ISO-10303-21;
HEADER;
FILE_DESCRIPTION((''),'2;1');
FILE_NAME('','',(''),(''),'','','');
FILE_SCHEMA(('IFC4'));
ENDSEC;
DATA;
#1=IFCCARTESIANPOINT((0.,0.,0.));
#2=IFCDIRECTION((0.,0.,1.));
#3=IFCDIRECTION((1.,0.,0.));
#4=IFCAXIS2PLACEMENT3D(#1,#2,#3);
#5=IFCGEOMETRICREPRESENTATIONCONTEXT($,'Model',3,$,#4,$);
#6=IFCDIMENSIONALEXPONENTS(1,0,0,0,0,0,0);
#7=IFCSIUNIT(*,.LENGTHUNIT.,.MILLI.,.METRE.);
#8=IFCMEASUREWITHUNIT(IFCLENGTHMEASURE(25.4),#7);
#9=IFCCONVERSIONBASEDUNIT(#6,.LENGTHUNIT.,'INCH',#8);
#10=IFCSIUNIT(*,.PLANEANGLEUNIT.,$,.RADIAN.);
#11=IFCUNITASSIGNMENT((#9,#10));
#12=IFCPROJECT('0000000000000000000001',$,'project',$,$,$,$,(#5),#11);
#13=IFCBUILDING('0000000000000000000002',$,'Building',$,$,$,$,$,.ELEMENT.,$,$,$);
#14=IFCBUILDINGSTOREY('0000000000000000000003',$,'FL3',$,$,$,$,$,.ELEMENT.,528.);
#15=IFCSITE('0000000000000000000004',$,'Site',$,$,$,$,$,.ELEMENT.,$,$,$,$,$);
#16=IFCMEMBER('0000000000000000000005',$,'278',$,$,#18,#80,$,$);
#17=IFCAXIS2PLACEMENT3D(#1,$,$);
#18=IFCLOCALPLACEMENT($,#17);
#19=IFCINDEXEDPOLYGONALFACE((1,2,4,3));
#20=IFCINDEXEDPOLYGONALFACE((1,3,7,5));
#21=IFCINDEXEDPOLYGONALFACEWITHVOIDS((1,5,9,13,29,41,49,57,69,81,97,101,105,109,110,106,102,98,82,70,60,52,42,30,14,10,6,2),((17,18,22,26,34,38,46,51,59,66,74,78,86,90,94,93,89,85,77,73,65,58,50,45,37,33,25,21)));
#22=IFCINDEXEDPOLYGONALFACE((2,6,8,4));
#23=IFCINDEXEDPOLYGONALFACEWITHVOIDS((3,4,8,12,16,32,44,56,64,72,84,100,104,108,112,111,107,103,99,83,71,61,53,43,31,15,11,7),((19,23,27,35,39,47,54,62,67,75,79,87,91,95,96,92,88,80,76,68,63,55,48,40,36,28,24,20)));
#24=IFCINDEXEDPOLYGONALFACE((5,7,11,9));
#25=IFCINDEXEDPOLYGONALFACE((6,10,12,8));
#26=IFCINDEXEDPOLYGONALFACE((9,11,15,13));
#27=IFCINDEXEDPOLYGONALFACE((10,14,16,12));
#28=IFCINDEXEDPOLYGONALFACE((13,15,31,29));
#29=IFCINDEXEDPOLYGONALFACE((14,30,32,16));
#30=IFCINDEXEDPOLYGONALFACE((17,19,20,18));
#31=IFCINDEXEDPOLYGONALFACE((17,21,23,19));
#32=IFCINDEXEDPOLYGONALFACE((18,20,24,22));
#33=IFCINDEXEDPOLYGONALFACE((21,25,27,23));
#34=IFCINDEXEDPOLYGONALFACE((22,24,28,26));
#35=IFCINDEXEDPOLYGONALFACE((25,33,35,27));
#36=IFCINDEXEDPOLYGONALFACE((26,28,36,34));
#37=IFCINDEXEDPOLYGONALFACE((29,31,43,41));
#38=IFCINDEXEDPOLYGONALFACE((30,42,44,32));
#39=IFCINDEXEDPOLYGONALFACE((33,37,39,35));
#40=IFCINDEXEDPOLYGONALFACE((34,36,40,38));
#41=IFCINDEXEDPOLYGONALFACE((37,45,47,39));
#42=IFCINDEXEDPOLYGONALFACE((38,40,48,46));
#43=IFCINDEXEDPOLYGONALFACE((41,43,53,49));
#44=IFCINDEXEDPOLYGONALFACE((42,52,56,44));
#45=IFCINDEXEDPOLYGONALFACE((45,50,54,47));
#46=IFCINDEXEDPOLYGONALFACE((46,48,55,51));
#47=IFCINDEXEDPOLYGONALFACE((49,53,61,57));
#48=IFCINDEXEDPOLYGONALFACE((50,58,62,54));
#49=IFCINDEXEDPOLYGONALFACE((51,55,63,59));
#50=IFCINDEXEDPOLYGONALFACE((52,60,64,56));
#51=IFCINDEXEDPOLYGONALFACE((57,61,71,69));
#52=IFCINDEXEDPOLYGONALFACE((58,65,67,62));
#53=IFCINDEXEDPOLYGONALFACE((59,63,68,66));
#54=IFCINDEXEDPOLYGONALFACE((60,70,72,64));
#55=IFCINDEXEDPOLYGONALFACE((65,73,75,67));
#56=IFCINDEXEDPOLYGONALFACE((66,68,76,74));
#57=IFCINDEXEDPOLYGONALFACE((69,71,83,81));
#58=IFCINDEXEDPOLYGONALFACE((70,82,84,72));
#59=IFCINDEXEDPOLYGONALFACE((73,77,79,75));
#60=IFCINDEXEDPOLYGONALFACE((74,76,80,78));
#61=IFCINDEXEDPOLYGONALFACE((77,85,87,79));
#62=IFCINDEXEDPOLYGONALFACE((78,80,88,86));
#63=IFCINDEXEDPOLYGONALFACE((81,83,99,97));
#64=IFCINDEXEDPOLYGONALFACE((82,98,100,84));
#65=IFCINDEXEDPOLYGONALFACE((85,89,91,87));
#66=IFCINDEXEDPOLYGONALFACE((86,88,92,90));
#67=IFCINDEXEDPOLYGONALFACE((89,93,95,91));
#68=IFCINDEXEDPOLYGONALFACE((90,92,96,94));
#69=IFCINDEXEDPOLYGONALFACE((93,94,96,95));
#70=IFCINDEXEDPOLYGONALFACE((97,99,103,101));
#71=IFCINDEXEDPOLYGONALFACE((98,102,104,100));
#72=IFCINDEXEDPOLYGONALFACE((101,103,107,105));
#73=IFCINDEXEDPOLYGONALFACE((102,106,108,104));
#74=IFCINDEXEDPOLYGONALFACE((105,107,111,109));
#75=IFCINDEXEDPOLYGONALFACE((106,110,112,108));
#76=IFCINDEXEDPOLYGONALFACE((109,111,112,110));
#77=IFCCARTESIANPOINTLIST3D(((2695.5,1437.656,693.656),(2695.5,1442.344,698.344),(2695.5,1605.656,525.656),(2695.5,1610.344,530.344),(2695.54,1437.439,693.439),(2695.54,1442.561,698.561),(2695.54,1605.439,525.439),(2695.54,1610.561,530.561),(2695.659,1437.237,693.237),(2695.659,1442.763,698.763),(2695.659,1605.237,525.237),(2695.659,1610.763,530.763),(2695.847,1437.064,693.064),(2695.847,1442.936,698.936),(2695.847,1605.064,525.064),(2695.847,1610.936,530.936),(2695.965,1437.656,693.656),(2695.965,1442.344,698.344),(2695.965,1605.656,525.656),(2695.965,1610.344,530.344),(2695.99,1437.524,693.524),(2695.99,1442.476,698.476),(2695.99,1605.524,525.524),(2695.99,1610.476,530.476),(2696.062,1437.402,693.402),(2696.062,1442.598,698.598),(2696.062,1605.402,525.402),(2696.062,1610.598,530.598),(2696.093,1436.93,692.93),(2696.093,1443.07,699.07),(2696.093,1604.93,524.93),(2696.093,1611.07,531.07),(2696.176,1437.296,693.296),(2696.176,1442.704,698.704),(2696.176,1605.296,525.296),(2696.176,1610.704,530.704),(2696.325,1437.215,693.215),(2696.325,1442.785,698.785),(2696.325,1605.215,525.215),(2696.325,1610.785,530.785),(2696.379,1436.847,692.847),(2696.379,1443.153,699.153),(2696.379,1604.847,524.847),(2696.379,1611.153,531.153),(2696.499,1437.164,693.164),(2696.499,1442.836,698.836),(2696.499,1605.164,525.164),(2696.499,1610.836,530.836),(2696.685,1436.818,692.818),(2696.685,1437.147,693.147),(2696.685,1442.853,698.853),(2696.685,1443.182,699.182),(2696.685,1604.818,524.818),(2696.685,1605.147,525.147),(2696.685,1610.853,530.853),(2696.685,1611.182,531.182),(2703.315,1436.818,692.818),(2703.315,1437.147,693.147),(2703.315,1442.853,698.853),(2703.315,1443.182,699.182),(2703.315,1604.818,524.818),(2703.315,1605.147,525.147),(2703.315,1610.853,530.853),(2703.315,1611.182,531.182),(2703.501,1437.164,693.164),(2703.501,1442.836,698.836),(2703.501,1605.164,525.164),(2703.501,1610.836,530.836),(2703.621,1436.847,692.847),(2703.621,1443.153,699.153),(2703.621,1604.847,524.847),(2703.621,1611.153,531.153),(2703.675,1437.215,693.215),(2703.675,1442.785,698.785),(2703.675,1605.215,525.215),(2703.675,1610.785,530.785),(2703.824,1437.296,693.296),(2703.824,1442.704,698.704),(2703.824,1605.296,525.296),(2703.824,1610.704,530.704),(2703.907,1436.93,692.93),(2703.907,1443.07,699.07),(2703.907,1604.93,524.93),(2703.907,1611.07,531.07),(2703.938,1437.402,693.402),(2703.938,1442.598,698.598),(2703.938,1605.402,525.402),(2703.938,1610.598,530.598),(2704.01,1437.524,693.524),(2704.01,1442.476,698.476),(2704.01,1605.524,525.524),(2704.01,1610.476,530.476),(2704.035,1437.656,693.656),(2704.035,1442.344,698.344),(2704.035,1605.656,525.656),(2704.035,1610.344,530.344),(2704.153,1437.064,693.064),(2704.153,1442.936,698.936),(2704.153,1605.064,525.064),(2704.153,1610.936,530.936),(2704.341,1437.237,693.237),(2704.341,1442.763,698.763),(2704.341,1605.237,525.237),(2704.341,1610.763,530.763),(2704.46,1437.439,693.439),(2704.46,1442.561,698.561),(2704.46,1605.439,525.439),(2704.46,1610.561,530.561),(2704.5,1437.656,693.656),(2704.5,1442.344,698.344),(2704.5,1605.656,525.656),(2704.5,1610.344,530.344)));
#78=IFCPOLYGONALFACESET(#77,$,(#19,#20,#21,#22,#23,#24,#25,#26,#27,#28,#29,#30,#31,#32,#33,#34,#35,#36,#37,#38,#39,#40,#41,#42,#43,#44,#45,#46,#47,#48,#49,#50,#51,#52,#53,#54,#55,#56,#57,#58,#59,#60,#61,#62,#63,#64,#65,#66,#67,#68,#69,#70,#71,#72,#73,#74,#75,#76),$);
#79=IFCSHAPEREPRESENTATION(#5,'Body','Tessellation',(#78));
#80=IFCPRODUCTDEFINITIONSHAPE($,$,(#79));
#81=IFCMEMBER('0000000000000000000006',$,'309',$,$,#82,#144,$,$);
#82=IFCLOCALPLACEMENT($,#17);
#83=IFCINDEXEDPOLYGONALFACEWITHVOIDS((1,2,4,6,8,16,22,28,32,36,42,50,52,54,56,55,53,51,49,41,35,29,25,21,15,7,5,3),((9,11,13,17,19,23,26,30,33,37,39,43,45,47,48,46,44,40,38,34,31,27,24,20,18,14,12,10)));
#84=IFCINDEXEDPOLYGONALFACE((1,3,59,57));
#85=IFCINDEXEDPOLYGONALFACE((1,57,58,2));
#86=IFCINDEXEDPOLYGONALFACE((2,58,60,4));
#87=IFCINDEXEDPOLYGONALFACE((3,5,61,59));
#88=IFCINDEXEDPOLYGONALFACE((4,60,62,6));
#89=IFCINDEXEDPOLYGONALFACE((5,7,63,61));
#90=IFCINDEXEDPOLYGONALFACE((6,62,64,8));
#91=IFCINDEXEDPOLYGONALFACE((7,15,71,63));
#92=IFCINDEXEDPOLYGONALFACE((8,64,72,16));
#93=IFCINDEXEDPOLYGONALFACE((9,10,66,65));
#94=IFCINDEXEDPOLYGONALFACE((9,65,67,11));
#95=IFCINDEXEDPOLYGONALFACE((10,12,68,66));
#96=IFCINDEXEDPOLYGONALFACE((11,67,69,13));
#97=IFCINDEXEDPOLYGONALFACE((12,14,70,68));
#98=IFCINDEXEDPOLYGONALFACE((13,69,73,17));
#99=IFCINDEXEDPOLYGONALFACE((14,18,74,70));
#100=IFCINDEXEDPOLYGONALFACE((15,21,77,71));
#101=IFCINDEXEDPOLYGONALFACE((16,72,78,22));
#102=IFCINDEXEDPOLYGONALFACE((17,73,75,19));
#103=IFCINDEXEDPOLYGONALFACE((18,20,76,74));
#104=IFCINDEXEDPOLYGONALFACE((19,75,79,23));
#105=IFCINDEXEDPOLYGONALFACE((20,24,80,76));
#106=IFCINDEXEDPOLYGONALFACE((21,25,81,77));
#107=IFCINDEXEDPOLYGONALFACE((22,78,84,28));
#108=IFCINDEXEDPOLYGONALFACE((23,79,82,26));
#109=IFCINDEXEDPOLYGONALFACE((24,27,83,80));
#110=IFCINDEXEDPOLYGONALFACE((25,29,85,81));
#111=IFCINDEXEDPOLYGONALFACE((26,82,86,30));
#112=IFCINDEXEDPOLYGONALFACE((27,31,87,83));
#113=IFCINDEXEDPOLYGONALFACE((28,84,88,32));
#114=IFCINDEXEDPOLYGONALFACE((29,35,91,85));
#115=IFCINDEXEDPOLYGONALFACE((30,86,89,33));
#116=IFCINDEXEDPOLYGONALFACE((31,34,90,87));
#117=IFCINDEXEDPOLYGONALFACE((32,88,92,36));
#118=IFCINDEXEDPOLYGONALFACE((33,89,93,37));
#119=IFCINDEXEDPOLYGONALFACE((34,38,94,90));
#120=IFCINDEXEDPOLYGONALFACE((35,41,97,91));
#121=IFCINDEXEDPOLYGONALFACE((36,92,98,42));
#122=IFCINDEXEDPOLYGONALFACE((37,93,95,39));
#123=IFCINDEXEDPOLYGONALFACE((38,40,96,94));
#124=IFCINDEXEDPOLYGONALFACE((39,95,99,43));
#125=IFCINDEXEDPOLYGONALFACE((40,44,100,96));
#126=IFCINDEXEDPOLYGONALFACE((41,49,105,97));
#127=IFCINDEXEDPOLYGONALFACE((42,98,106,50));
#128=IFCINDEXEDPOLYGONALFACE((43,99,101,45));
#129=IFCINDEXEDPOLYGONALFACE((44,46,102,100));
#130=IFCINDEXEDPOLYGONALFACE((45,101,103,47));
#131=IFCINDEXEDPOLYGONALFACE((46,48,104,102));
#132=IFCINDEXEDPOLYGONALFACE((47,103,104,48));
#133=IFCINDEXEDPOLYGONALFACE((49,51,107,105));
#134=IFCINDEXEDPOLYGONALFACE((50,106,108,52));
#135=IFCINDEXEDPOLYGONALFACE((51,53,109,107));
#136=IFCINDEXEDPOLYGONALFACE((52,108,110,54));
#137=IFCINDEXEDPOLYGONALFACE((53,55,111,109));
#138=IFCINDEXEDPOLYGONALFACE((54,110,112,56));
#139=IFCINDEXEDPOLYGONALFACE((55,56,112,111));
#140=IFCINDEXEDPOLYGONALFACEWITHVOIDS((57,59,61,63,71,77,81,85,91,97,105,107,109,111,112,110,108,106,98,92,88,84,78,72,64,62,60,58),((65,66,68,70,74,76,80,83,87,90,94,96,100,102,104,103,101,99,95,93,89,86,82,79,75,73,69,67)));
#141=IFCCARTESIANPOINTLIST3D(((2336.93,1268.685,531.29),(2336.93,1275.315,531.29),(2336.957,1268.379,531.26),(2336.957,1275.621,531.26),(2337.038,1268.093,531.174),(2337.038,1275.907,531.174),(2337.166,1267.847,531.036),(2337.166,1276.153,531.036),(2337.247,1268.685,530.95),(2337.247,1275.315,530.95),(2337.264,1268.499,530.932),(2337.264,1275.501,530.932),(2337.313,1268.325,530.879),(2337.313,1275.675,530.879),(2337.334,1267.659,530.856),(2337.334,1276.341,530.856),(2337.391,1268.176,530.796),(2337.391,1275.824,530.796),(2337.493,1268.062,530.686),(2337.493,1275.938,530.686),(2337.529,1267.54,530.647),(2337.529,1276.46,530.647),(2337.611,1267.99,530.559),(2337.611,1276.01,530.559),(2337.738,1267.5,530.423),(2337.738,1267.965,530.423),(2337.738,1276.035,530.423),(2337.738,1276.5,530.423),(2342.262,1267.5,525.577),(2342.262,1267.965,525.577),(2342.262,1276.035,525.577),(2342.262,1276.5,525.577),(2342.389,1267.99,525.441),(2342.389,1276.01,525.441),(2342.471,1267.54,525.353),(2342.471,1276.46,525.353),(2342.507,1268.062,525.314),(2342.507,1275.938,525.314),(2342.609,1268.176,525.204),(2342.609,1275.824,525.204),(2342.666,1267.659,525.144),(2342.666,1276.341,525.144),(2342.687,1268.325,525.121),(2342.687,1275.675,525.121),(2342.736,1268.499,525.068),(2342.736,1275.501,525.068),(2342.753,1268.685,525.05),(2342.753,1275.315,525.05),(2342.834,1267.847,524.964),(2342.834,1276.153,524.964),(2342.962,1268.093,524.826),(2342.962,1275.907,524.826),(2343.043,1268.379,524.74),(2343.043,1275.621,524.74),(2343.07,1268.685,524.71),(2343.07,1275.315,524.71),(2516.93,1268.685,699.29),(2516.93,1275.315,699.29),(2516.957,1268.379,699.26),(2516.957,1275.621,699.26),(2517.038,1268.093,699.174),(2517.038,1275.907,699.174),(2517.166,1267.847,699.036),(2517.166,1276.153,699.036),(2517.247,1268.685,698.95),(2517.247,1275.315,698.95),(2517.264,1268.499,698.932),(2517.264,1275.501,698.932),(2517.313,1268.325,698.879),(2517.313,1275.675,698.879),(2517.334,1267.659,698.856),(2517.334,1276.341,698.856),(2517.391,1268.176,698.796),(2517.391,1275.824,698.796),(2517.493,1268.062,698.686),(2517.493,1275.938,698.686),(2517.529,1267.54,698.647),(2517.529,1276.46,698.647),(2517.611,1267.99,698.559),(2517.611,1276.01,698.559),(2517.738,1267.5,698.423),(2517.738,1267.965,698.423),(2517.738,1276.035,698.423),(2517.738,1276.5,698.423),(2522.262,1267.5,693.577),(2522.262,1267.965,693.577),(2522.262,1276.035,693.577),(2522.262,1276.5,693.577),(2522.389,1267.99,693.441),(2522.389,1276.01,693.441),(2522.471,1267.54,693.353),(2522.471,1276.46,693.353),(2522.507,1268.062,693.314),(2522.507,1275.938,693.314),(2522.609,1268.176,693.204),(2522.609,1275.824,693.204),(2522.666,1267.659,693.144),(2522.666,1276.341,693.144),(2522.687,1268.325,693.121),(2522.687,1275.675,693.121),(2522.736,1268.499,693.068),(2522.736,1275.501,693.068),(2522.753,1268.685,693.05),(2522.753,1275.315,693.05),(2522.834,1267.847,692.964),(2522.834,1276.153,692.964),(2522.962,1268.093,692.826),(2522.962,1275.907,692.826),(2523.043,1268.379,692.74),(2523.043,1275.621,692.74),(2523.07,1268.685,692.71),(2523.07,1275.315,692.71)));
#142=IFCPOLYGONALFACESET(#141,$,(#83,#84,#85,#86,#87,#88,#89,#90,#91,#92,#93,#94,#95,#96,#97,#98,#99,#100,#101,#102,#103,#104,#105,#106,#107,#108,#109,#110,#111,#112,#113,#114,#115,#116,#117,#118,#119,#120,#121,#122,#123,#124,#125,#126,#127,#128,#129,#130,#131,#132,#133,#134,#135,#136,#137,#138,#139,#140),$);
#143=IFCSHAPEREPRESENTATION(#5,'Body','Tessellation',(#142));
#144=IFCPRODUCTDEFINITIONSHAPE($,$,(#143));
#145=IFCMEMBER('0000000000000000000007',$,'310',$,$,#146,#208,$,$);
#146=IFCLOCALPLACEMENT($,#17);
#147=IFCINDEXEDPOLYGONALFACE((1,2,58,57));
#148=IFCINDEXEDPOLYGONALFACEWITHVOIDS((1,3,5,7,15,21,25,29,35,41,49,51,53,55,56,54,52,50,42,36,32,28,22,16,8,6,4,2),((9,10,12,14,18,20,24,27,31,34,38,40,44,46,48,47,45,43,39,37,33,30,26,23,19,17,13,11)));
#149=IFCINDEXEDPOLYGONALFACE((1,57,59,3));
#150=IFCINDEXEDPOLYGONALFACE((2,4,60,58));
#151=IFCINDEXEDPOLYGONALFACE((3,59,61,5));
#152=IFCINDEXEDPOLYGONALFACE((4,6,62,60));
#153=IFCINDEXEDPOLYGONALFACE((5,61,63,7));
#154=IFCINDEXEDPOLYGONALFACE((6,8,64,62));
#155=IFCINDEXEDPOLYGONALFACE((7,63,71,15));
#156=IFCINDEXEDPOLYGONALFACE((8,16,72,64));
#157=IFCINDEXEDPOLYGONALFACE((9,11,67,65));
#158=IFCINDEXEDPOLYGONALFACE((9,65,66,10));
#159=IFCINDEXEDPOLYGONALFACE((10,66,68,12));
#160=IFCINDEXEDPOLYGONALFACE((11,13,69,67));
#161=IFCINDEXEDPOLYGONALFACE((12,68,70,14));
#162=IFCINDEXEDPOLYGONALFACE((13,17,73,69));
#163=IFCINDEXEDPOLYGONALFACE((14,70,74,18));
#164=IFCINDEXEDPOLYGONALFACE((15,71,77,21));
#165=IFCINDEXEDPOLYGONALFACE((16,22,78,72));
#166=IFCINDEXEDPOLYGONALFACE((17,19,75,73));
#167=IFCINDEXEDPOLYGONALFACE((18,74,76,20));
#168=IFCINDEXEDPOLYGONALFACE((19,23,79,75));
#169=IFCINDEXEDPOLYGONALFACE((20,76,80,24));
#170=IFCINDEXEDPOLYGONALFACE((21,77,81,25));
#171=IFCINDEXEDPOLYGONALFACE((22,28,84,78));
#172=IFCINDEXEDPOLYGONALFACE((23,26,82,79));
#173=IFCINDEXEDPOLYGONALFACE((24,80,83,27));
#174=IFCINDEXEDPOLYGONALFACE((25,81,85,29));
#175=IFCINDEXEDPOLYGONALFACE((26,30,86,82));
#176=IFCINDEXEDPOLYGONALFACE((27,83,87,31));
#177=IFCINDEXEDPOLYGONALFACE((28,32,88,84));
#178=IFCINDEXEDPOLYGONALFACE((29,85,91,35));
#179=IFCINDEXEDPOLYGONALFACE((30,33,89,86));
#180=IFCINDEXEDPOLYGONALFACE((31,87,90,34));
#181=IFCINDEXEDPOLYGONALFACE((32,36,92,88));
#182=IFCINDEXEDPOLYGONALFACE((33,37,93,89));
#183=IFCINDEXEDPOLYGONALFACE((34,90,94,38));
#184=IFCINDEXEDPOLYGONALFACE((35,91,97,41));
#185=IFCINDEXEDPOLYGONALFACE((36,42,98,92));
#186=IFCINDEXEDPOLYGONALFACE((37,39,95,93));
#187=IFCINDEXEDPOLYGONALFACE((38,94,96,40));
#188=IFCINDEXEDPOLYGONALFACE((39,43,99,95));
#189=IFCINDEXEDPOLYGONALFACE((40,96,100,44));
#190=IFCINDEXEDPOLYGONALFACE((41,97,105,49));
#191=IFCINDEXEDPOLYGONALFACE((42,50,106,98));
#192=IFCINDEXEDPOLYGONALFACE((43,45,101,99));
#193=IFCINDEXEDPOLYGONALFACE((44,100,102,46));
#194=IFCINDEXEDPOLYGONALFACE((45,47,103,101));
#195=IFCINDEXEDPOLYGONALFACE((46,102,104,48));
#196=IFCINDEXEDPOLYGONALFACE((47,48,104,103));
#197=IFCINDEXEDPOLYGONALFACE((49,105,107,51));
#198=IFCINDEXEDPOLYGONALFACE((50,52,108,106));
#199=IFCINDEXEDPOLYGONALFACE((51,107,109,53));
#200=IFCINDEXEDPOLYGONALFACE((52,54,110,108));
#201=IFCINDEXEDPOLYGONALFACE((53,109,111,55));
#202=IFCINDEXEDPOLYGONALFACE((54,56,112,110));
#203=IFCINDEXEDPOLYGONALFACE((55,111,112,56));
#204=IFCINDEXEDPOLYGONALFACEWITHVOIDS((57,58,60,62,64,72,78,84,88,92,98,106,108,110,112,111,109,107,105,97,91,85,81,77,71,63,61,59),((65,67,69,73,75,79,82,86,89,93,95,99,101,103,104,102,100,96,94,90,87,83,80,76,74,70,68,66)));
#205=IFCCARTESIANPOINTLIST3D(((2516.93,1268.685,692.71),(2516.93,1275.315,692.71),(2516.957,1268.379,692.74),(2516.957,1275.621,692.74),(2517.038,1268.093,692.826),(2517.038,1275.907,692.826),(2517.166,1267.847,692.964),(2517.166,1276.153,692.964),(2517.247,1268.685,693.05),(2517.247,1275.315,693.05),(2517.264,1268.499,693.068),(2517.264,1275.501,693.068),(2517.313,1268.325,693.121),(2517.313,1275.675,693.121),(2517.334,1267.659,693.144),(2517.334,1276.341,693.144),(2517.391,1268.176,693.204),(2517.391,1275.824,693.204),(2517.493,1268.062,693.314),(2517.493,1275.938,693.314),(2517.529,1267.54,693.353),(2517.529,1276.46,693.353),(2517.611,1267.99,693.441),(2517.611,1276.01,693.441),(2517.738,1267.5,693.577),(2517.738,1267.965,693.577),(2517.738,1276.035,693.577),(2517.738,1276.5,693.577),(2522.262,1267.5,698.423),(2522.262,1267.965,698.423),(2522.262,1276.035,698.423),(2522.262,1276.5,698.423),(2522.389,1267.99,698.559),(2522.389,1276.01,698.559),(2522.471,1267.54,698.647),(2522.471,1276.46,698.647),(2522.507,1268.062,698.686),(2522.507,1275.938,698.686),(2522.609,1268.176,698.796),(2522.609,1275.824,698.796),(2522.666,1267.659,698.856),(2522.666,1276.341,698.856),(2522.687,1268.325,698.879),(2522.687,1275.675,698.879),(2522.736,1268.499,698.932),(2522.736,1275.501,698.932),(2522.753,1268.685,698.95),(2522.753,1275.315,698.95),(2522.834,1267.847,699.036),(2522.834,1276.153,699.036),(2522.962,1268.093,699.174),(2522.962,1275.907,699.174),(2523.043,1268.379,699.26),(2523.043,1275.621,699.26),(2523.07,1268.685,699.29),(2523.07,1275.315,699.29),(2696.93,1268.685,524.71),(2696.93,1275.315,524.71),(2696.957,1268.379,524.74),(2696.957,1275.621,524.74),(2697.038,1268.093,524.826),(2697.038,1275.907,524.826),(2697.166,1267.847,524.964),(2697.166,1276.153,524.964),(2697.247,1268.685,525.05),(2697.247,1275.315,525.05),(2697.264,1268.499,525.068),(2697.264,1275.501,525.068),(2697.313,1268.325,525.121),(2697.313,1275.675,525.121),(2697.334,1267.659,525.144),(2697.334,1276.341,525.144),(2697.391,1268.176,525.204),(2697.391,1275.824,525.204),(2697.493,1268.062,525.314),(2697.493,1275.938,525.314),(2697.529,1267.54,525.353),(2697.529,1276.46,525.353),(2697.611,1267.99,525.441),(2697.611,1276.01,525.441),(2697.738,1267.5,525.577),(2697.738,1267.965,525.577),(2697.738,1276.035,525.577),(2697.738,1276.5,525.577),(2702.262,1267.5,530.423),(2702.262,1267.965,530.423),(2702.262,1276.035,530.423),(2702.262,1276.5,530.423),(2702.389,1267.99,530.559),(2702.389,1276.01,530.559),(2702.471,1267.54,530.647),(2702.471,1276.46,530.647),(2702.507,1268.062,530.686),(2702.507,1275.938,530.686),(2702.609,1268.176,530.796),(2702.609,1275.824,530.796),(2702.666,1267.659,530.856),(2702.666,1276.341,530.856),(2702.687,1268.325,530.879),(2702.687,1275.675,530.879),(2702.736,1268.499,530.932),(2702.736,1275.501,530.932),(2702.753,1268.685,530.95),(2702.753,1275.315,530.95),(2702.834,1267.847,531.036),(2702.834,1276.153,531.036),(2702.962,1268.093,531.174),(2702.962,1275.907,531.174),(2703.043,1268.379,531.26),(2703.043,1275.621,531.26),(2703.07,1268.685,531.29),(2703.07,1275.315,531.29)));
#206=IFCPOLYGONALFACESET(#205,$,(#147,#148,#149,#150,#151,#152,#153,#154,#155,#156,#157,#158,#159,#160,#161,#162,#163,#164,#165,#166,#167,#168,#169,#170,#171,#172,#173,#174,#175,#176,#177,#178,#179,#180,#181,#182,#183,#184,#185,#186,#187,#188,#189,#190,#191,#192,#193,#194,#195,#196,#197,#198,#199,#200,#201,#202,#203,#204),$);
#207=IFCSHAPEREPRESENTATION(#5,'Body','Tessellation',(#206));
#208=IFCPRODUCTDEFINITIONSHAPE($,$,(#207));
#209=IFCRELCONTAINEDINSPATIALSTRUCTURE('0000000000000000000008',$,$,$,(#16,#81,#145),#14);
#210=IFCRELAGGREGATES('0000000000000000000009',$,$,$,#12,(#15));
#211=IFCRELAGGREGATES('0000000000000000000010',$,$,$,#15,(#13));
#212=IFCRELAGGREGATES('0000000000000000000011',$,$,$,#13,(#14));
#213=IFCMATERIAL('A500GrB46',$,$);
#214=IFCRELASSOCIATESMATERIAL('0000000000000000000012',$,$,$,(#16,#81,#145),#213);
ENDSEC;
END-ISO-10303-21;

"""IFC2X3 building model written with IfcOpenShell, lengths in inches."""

from ifc_helpers import new_model, entity, si_unit, converted_unit, frame, origin_with_axes, origin_2d_with_axis, place, context, project, spatial, hollow_rectangle, extrude, material, element, save


model = new_model("IFC2X3")

# Units and contexts
model_context = context("Model", 3, world=origin_with_axes())
ifc_project = project(units=[converted_unit("LENGTHUNIT", "INCH", entity("IfcLengthMeasure", 25.4), si_unit("LENGTHUNIT", "METRE", prefix="MILLI"), dimensions=[1, 0, 0, 0, 0, 0, 0]), si_unit("PLANEANGLEUNIT", "RADIAN")], contexts=[model_context])

# Site, building, storey
site = spatial("IfcSite", under=ifc_project, Name="Site", CompositionType="ELEMENT")
building = spatial("IfcBuilding", under=site, Name="Building", CompositionType="ELEMENT")
storey = spatial("IfcBuildingStorey", under=building, Name="FL3", CompositionType="ELEMENT", Elevation=528.0)

# Members
ifc_material_1 = material(Name="A500GrB46")
for number, where, z_axis, x_axis, name in (
    (1, (2700.0, 1608.0, 528.0), (0.0, -0.707107, 0.707107), (1.0, 0.0, 0.0), "278"),
):
    element("IfcMember", number, at=place(None, frame(where, z_axis=z_axis, x_axis=x_axis)), inside=storey, material=ifc_material_1, Name=name, context=model_context, shape_type="SweptSolid", body=[
        extrude(hollow_rectangle(XDim=9.0, YDim=9.0, WallThickness=0.465, InnerFilletRadius=0.72, OuterFilletRadius=1.185, at=origin_2d_with_axis()), origin_with_axes(), (0.0, 0.0, 1.0), 237.588),
    ])
for number, where, z_axis, x_axis, name in (
    (2, (2340.0, 1272.0, 528.0), (0.731055, 0.0, 0.682318), (0.0, 1.0, 0.0), "309"),
    (3, (2700.0, 1272.0, 528.0), (-0.731055, 0.0, 0.682318), (0.0, -1.0, 0.0), "310"),
):
    element("IfcMember", number, at=place(None, frame(where, z_axis=z_axis, x_axis=x_axis)), inside=storey, material=ifc_material_1, Name=name, context=model_context, shape_type="SweptSolid", body=[
        extrude(hollow_rectangle(XDim=9.0, YDim=9.0, WallThickness=0.465, InnerFilletRadius=0.72, OuterFilletRadius=1.185, at=origin_2d_with_axis()), origin_with_axes(), (0.0, 0.0, 1.0), 246.219),
    ])

save(model, "model.ifc")
